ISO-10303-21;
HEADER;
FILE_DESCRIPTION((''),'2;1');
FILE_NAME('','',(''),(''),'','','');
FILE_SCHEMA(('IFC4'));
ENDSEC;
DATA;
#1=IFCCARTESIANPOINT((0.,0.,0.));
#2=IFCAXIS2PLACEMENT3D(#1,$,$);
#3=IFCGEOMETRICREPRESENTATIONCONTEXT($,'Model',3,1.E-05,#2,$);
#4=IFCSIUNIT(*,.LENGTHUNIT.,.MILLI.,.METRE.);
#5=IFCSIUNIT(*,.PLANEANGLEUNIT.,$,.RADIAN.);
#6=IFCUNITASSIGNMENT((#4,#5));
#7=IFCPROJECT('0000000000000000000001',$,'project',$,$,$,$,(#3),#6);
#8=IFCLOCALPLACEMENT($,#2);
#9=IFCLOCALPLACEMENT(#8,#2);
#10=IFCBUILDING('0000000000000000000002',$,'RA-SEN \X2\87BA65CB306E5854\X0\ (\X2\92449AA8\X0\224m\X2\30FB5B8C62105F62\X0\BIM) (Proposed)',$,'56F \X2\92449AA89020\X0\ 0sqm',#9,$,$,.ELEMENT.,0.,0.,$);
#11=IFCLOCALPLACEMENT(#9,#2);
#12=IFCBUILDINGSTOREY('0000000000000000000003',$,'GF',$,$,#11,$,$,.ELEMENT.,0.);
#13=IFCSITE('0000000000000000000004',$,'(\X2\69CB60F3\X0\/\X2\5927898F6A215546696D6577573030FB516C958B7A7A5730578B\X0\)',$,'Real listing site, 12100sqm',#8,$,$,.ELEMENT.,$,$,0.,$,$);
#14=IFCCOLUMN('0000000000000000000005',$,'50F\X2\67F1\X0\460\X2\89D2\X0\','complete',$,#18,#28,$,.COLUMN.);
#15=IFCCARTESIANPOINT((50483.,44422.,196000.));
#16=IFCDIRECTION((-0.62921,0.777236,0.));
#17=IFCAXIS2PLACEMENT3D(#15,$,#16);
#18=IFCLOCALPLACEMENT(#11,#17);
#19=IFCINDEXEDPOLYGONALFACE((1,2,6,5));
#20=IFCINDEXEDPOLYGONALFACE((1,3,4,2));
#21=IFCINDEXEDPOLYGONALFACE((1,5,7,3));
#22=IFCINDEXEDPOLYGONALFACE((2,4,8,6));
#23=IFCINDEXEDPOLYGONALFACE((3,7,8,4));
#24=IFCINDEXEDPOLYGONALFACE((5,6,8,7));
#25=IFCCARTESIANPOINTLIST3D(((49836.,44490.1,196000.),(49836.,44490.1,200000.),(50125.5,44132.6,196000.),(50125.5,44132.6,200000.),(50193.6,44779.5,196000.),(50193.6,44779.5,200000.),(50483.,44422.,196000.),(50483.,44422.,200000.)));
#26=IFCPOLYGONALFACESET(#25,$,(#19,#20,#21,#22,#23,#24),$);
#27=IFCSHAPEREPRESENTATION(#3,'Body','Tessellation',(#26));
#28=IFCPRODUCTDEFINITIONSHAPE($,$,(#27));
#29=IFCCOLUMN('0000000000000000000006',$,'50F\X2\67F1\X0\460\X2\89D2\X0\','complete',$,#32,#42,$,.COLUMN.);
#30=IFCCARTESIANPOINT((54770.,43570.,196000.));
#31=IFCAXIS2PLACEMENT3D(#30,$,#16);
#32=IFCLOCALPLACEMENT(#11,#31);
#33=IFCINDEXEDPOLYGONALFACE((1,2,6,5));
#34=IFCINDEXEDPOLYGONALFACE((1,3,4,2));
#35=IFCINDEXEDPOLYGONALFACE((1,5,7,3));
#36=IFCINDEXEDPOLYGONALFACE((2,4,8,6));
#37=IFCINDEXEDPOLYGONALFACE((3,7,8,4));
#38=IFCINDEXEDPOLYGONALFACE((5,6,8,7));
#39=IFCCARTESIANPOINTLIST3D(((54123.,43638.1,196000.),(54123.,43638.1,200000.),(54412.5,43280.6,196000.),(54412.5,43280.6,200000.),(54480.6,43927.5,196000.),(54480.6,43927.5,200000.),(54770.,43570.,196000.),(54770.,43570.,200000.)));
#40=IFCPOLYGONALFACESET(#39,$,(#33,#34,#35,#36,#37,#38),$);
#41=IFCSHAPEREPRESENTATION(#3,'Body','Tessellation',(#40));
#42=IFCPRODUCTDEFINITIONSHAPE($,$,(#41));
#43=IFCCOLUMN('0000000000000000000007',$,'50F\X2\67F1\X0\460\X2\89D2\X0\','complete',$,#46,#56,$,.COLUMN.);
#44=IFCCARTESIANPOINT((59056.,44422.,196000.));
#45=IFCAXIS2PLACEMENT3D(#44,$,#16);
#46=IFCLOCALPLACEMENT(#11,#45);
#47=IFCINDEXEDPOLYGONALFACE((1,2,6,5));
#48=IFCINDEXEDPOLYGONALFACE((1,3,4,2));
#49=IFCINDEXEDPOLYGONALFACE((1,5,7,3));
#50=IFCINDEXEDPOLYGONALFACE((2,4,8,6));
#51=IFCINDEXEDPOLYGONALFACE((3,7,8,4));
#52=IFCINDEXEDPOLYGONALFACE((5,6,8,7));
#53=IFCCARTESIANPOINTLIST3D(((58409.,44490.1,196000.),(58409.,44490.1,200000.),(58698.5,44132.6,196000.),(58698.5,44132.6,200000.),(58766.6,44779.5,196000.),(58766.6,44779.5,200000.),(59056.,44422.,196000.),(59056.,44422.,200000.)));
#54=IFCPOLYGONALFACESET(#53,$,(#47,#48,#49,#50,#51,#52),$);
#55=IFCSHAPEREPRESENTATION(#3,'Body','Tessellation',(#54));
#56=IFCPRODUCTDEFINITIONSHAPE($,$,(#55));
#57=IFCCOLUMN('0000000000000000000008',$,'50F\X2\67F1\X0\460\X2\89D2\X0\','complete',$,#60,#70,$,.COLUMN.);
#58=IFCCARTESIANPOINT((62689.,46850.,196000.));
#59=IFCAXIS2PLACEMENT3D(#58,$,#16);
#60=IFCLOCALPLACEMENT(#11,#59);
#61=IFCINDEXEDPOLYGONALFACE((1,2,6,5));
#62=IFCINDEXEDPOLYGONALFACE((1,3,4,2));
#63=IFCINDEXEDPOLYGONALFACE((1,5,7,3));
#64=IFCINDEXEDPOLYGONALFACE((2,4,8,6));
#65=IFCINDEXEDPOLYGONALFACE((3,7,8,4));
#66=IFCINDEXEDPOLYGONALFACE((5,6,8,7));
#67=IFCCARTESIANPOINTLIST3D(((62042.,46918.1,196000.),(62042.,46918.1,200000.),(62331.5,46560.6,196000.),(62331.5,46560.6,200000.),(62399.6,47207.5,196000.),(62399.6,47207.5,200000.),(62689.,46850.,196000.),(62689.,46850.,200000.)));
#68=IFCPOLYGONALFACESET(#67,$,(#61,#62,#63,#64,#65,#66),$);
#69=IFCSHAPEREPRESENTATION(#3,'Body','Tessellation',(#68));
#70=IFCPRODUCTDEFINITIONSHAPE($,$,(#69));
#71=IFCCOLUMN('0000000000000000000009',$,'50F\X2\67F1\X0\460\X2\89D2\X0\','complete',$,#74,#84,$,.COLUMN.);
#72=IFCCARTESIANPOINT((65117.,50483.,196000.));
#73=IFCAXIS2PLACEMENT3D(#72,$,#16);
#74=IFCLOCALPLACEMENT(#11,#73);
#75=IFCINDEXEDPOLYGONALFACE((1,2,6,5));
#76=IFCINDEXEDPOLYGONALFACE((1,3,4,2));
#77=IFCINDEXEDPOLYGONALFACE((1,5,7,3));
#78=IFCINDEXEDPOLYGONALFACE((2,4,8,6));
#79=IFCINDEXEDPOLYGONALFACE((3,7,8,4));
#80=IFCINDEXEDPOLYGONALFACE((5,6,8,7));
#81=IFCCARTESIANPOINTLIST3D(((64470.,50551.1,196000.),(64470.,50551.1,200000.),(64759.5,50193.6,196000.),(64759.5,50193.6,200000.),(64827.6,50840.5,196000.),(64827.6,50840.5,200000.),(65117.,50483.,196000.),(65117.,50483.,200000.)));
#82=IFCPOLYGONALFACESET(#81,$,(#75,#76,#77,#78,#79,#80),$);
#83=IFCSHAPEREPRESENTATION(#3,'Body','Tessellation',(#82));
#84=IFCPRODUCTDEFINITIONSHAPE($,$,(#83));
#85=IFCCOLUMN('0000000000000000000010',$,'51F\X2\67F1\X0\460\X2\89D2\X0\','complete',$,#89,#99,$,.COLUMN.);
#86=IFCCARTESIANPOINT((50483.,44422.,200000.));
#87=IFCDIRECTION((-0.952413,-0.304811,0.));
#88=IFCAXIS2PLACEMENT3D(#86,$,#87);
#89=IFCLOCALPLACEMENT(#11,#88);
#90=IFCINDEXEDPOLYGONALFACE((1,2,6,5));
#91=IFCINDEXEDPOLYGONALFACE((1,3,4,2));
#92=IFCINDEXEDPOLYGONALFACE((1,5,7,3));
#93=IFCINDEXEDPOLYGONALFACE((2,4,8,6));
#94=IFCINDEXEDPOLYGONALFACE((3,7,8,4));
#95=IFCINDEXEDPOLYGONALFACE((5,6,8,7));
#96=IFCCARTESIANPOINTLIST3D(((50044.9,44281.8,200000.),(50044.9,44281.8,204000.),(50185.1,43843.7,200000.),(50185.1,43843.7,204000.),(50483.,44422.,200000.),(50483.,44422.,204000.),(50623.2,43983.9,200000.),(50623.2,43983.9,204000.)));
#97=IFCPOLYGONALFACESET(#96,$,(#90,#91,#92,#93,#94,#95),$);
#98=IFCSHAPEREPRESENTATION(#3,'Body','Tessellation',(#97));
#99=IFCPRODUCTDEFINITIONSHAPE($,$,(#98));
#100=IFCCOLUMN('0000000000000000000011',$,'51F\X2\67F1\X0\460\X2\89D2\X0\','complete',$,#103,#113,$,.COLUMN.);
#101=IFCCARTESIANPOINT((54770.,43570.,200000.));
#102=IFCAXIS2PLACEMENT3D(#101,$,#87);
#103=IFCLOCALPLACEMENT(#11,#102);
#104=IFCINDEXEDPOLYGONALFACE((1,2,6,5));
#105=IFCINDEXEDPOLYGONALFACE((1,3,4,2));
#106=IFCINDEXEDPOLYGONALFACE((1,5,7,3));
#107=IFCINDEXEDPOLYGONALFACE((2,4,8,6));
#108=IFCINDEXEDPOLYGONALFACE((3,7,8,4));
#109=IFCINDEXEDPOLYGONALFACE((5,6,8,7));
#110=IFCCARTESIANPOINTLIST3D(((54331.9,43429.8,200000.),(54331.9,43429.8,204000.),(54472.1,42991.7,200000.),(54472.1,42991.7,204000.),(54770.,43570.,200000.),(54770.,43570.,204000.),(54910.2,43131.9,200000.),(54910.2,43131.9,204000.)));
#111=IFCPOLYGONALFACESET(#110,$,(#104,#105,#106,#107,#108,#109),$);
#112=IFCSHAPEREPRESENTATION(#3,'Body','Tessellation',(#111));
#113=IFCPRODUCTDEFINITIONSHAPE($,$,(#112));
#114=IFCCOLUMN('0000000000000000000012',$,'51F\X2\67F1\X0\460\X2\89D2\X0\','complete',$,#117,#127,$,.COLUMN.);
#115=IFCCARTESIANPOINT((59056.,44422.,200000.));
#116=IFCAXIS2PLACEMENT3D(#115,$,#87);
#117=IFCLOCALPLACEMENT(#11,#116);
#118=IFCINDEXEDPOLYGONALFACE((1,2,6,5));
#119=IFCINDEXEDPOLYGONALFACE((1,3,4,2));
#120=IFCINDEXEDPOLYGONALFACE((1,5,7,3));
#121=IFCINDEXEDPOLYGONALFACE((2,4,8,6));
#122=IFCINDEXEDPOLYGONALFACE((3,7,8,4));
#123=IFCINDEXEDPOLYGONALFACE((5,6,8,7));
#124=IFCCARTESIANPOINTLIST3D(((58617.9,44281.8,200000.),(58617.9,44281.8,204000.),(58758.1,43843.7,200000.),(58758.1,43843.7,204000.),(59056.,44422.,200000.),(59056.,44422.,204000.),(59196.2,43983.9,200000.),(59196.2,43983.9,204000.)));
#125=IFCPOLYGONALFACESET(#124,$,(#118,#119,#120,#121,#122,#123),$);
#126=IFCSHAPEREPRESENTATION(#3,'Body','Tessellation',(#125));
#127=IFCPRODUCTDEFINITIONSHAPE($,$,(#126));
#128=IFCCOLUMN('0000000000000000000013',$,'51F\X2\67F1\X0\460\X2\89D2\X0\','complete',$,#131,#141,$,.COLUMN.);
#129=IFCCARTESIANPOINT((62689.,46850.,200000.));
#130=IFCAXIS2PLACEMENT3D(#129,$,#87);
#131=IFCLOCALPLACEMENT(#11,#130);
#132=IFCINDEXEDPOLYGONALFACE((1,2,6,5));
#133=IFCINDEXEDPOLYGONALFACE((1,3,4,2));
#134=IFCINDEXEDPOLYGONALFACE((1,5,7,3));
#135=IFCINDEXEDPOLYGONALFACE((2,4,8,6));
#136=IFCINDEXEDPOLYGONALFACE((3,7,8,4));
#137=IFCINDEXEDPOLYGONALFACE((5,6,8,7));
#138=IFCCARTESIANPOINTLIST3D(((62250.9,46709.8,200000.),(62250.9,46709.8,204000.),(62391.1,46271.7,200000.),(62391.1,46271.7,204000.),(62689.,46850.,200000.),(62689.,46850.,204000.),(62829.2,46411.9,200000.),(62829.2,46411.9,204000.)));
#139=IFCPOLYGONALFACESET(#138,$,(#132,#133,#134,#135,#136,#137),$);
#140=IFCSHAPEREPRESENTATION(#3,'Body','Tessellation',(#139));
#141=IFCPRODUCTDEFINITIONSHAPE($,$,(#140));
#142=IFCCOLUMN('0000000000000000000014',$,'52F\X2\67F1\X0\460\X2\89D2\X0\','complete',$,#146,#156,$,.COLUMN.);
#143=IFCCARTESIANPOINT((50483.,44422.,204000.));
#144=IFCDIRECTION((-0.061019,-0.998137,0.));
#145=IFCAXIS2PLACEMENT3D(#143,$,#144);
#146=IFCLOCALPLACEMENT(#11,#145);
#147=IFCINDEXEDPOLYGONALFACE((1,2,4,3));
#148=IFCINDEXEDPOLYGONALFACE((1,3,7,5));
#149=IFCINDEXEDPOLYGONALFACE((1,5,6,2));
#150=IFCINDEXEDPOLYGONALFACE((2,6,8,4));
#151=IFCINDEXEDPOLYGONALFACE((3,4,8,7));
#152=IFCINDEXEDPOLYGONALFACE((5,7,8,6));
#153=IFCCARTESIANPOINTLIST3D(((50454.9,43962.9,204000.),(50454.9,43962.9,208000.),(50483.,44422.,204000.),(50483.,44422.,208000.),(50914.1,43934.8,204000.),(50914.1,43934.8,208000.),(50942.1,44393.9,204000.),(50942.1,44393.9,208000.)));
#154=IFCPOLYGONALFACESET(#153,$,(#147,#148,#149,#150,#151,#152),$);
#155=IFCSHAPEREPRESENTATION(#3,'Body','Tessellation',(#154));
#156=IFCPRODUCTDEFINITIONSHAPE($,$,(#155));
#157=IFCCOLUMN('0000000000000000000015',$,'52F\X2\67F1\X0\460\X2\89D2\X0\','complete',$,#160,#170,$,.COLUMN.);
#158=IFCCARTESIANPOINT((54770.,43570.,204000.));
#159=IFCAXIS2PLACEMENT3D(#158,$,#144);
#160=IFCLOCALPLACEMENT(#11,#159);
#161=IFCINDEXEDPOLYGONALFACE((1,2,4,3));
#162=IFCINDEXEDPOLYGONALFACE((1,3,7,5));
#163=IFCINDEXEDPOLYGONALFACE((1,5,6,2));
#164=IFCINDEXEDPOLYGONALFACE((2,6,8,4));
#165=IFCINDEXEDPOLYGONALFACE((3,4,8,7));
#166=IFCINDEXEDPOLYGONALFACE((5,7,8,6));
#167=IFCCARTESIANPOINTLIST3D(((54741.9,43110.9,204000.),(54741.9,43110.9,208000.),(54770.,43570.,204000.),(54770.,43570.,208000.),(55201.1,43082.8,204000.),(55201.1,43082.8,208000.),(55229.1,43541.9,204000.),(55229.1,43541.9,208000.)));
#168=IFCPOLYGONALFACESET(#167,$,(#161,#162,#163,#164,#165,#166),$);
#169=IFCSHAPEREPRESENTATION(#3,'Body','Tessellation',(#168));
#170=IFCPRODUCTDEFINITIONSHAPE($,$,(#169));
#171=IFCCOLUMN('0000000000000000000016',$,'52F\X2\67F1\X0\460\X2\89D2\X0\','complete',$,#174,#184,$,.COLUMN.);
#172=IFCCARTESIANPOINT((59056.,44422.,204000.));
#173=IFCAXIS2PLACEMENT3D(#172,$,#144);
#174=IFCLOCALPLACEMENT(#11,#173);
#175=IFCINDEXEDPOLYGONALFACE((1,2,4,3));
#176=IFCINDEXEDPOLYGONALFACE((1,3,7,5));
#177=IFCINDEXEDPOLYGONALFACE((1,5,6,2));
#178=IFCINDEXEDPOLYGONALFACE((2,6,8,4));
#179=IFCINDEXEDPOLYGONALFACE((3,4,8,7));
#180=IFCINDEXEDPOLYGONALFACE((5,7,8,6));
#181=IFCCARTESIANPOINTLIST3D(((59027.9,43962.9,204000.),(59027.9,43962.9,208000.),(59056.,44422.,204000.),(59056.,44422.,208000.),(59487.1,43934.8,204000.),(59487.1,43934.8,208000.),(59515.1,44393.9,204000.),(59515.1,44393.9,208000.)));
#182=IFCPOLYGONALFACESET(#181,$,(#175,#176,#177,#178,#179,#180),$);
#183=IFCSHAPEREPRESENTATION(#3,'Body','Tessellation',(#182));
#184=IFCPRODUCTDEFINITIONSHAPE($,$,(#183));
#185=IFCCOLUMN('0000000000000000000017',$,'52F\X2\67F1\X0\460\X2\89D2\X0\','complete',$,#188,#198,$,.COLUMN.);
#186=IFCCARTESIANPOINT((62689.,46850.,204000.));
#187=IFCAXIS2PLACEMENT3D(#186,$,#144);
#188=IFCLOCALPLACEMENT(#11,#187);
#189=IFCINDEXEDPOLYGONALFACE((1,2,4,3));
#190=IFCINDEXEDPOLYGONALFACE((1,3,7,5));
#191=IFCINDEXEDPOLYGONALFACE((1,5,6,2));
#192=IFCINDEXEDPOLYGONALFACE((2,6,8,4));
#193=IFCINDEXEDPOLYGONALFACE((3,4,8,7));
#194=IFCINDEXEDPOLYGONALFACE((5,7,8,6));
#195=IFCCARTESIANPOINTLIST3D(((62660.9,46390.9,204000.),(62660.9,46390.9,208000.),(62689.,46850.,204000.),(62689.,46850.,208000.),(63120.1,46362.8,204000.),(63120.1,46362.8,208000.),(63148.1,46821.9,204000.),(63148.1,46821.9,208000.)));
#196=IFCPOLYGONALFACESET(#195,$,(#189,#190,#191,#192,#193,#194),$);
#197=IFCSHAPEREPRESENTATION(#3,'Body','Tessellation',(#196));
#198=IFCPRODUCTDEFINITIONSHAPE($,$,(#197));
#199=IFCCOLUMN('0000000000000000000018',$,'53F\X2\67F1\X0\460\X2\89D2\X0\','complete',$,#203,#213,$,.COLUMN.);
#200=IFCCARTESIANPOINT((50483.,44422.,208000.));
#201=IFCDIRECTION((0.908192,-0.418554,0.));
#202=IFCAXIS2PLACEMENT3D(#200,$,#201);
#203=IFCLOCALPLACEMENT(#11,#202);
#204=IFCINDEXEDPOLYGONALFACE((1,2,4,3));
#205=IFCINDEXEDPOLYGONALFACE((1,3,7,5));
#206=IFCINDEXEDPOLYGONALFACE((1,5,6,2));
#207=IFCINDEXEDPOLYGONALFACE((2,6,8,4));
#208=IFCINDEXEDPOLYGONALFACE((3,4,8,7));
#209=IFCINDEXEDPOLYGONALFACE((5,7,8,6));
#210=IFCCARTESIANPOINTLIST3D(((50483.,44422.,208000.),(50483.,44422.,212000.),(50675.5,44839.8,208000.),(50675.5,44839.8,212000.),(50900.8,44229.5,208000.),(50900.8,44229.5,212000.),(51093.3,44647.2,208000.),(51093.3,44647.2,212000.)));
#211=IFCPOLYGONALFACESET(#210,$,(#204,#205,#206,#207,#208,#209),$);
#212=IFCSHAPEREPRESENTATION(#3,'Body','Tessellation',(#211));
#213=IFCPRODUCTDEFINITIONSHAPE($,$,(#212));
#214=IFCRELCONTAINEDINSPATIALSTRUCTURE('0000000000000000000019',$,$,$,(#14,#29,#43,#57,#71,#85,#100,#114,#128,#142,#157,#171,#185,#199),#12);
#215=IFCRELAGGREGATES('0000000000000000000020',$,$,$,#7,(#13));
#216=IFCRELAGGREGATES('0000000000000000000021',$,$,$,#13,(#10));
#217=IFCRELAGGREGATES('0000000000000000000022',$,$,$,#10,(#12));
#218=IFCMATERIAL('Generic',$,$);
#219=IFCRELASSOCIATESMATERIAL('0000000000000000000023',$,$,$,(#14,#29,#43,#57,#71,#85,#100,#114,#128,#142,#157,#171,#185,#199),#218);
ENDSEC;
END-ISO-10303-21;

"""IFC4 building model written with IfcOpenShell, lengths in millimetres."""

from ifc_helpers import new_model, si_unit, frame, frame_2d, origin, place, context, project, spatial, rectangle, extrude, material, element, save


model = new_model("IFC4")

# Units and contexts
model_context = context("Model", 3, precision=1e-05, world=origin())
ifc_project = project(units=[si_unit("LENGTHUNIT", "METRE", prefix="MILLI"), si_unit("PLANEANGLEUNIT", "RADIAN")], contexts=[model_context])

# Site, building, storey
site_placement = place(None, origin())
site = spatial("IfcSite", under=ifc_project, at=site_placement, Name="(構想/大規模商業敷地・公開空地型)", ObjectType="Real listing site, 12100sqm", CompositionType="ELEMENT", RefElevation=0.0)
building_placement = place(site_placement, origin())
building = spatial("IfcBuilding", under=site, at=building_placement, Name="RA-SEN 螺旋の塔 (鉄骨224m・完成形BIM) (Proposed)", ObjectType="56F 鉄骨造 0sqm", CompositionType="ELEMENT", ElevationOfRefHeight=0.0, ElevationOfTerrain=0.0)
storey_placement = place(building_placement, origin())
storey = spatial("IfcBuildingStorey", under=building, at=storey_placement, Name="GF", CompositionType="ELEMENT", Elevation=0.0)

# Columns
ifc_material = material(Name="Generic")
column_1_placement = place(storey_placement, frame((50483.0, 44422.0, 196000.0), x_axis=(-0.62921, 0.777236, 0.0)))
element("IfcColumn", 1, at=column_1_placement, inside=storey, material=ifc_material, Name="50F柱460角", Description="complete", PredefinedType="COLUMN", context=model_context, shape_type="SweptSolid", body=[
    extrude(rectangle(XDim=460.0, YDim=460.0, at=frame_2d((230.0, 230.0))), frame((50483.0, 44422.0, 196000.0), x_axis=(-0.62921, 0.777236, 0.0)), (0.0, 0.0, 1.0), 4000.0),
])
column_2_placement = place(storey_placement, frame((54770.0, 43570.0, 196000.0), x_axis=(-0.62921, 0.777236, 0.0)))
element("IfcColumn", 2, at=column_2_placement, inside=storey, material=ifc_material, Name="50F柱460角", Description="complete", PredefinedType="COLUMN", context=model_context, shape_type="SweptSolid", body=[
    extrude(rectangle(XDim=460.0, YDim=460.0, at=frame_2d((230.0, 230.0))), frame((54770.0, 43570.0, 196000.0), x_axis=(-0.62921, 0.777236, 0.0)), (0.0, 0.0, 1.0), 4000.0),
])
column_3_placement = place(storey_placement, frame((59056.0, 44422.0, 196000.0), x_axis=(-0.62921, 0.777236, 0.0)))
element("IfcColumn", 3, at=column_3_placement, inside=storey, material=ifc_material, Name="50F柱460角", Description="complete", PredefinedType="COLUMN", context=model_context, shape_type="SweptSolid", body=[
    extrude(rectangle(XDim=460.0, YDim=460.0, at=frame_2d((230.0, 230.0))), frame((59056.0, 44422.0, 196000.0), x_axis=(-0.62921, 0.777236, 0.0)), (0.0, 0.0, 1.0), 4000.0),
])
column_4_placement = place(storey_placement, frame((62689.0, 46850.0, 196000.0), x_axis=(-0.62921, 0.777236, 0.0)))
element("IfcColumn", 4, at=column_4_placement, inside=storey, material=ifc_material, Name="50F柱460角", Description="complete", PredefinedType="COLUMN", context=model_context, shape_type="SweptSolid", body=[
    extrude(rectangle(XDim=460.0, YDim=460.0, at=frame_2d((230.0, 230.0))), frame((62689.0, 46850.0, 196000.0), x_axis=(-0.62921, 0.777236, 0.0)), (0.0, 0.0, 1.0), 4000.0),
])
column_5_placement = place(storey_placement, frame((65117.0, 50483.0, 196000.0), x_axis=(-0.62921, 0.777236, 0.0)))
element("IfcColumn", 5, at=column_5_placement, inside=storey, material=ifc_material, Name="50F柱460角", Description="complete", PredefinedType="COLUMN", context=model_context, shape_type="SweptSolid", body=[
    extrude(rectangle(XDim=460.0, YDim=460.0, at=frame_2d((230.0, 230.0))), frame((65117.0, 50483.0, 196000.0), x_axis=(-0.62921, 0.777236, 0.0)), (0.0, 0.0, 1.0), 4000.0),
])
column_6_placement = place(storey_placement, frame((50483.0, 44422.0, 200000.0), x_axis=(-0.952413, -0.304811, 0.0)))
element("IfcColumn", 6, at=column_6_placement, inside=storey, material=ifc_material, Name="51F柱460角", Description="complete", PredefinedType="COLUMN", context=model_context, shape_type="SweptSolid", body=[
    extrude(rectangle(XDim=460.0, YDim=460.0, at=frame_2d((230.0, 230.0))), frame((50483.0, 44422.0, 200000.0), x_axis=(-0.952413, -0.304811, 0.0)), (0.0, 0.0, 1.0), 4000.0),
])
column_7_placement = place(storey_placement, frame((54770.0, 43570.0, 200000.0), x_axis=(-0.952413, -0.304811, 0.0)))
element("IfcColumn", 7, at=column_7_placement, inside=storey, material=ifc_material, Name="51F柱460角", Description="complete", PredefinedType="COLUMN", context=model_context, shape_type="SweptSolid", body=[
    extrude(rectangle(XDim=460.0, YDim=460.0, at=frame_2d((230.0, 230.0))), frame((54770.0, 43570.0, 200000.0), x_axis=(-0.952413, -0.304811, 0.0)), (0.0, 0.0, 1.0), 4000.0),
])
column_8_placement = place(storey_placement, frame((59056.0, 44422.0, 200000.0), x_axis=(-0.952413, -0.304811, 0.0)))
element("IfcColumn", 8, at=column_8_placement, inside=storey, material=ifc_material, Name="51F柱460角", Description="complete", PredefinedType="COLUMN", context=model_context, shape_type="SweptSolid", body=[
    extrude(rectangle(XDim=460.0, YDim=460.0, at=frame_2d((230.0, 230.0))), frame((59056.0, 44422.0, 200000.0), x_axis=(-0.952413, -0.304811, 0.0)), (0.0, 0.0, 1.0), 4000.0),
])
column_9_placement = place(storey_placement, frame((62689.0, 46850.0, 200000.0), x_axis=(-0.952413, -0.304811, 0.0)))
element("IfcColumn", 9, at=column_9_placement, inside=storey, material=ifc_material, Name="51F柱460角", Description="complete", PredefinedType="COLUMN", context=model_context, shape_type="SweptSolid", body=[
    extrude(rectangle(XDim=460.0, YDim=460.0, at=frame_2d((230.0, 230.0))), frame((62689.0, 46850.0, 200000.0), x_axis=(-0.952413, -0.304811, 0.0)), (0.0, 0.0, 1.0), 4000.0),
])
column_10_placement = place(storey_placement, frame((50483.0, 44422.0, 204000.0), x_axis=(-0.061019, -0.998137, 0.0)))
element("IfcColumn", 10, at=column_10_placement, inside=storey, material=ifc_material, Name="52F柱460角", Description="complete", PredefinedType="COLUMN", context=model_context, shape_type="SweptSolid", body=[
    extrude(rectangle(XDim=460.0, YDim=460.0, at=frame_2d((230.0, 230.0))), frame((50483.0, 44422.0, 204000.0), x_axis=(-0.061019, -0.998137, 0.0)), (0.0, 0.0, 1.0), 4000.0),
])
column_11_placement = place(storey_placement, frame((54770.0, 43570.0, 204000.0), x_axis=(-0.061019, -0.998137, 0.0)))
element("IfcColumn", 11, at=column_11_placement, inside=storey, material=ifc_material, Name="52F柱460角", Description="complete", PredefinedType="COLUMN", context=model_context, shape_type="SweptSolid", body=[
    extrude(rectangle(XDim=460.0, YDim=460.0, at=frame_2d((230.0, 230.0))), frame((54770.0, 43570.0, 204000.0), x_axis=(-0.061019, -0.998137, 0.0)), (0.0, 0.0, 1.0), 4000.0),
])
column_12_placement = place(storey_placement, frame((59056.0, 44422.0, 204000.0), x_axis=(-0.061019, -0.998137, 0.0)))
element("IfcColumn", 12, at=column_12_placement, inside=storey, material=ifc_material, Name="52F柱460角", Description="complete", PredefinedType="COLUMN", context=model_context, shape_type="SweptSolid", body=[
    extrude(rectangle(XDim=460.0, YDim=460.0, at=frame_2d((230.0, 230.0))), frame((59056.0, 44422.0, 204000.0), x_axis=(-0.061019, -0.998137, 0.0)), (0.0, 0.0, 1.0), 4000.0),
])
column_13_placement = place(storey_placement, frame((62689.0, 46850.0, 204000.0), x_axis=(-0.061019, -0.998137, 0.0)))
element("IfcColumn", 13, at=column_13_placement, inside=storey, material=ifc_material, Name="52F柱460角", Description="complete", PredefinedType="COLUMN", context=model_context, shape_type="SweptSolid", body=[
    extrude(rectangle(XDim=460.0, YDim=460.0, at=frame_2d((230.0, 230.0))), frame((62689.0, 46850.0, 204000.0), x_axis=(-0.061019, -0.998137, 0.0)), (0.0, 0.0, 1.0), 4000.0),
])
column_14_placement = place(storey_placement, frame((50483.0, 44422.0, 208000.0), x_axis=(0.908192, -0.418554, 0.0)))
element("IfcColumn", 14, at=column_14_placement, inside=storey, material=ifc_material, Name="53F柱460角", Description="complete", PredefinedType="COLUMN", context=model_context, shape_type="SweptSolid", body=[
    extrude(rectangle(XDim=460.0, YDim=460.0, at=frame_2d((230.0, 230.0))), frame((50483.0, 44422.0, 208000.0), x_axis=(0.908192, -0.418554, 0.0)), (0.0, 0.0, 1.0), 4000.0),
])

save(model, "model.ifc")
